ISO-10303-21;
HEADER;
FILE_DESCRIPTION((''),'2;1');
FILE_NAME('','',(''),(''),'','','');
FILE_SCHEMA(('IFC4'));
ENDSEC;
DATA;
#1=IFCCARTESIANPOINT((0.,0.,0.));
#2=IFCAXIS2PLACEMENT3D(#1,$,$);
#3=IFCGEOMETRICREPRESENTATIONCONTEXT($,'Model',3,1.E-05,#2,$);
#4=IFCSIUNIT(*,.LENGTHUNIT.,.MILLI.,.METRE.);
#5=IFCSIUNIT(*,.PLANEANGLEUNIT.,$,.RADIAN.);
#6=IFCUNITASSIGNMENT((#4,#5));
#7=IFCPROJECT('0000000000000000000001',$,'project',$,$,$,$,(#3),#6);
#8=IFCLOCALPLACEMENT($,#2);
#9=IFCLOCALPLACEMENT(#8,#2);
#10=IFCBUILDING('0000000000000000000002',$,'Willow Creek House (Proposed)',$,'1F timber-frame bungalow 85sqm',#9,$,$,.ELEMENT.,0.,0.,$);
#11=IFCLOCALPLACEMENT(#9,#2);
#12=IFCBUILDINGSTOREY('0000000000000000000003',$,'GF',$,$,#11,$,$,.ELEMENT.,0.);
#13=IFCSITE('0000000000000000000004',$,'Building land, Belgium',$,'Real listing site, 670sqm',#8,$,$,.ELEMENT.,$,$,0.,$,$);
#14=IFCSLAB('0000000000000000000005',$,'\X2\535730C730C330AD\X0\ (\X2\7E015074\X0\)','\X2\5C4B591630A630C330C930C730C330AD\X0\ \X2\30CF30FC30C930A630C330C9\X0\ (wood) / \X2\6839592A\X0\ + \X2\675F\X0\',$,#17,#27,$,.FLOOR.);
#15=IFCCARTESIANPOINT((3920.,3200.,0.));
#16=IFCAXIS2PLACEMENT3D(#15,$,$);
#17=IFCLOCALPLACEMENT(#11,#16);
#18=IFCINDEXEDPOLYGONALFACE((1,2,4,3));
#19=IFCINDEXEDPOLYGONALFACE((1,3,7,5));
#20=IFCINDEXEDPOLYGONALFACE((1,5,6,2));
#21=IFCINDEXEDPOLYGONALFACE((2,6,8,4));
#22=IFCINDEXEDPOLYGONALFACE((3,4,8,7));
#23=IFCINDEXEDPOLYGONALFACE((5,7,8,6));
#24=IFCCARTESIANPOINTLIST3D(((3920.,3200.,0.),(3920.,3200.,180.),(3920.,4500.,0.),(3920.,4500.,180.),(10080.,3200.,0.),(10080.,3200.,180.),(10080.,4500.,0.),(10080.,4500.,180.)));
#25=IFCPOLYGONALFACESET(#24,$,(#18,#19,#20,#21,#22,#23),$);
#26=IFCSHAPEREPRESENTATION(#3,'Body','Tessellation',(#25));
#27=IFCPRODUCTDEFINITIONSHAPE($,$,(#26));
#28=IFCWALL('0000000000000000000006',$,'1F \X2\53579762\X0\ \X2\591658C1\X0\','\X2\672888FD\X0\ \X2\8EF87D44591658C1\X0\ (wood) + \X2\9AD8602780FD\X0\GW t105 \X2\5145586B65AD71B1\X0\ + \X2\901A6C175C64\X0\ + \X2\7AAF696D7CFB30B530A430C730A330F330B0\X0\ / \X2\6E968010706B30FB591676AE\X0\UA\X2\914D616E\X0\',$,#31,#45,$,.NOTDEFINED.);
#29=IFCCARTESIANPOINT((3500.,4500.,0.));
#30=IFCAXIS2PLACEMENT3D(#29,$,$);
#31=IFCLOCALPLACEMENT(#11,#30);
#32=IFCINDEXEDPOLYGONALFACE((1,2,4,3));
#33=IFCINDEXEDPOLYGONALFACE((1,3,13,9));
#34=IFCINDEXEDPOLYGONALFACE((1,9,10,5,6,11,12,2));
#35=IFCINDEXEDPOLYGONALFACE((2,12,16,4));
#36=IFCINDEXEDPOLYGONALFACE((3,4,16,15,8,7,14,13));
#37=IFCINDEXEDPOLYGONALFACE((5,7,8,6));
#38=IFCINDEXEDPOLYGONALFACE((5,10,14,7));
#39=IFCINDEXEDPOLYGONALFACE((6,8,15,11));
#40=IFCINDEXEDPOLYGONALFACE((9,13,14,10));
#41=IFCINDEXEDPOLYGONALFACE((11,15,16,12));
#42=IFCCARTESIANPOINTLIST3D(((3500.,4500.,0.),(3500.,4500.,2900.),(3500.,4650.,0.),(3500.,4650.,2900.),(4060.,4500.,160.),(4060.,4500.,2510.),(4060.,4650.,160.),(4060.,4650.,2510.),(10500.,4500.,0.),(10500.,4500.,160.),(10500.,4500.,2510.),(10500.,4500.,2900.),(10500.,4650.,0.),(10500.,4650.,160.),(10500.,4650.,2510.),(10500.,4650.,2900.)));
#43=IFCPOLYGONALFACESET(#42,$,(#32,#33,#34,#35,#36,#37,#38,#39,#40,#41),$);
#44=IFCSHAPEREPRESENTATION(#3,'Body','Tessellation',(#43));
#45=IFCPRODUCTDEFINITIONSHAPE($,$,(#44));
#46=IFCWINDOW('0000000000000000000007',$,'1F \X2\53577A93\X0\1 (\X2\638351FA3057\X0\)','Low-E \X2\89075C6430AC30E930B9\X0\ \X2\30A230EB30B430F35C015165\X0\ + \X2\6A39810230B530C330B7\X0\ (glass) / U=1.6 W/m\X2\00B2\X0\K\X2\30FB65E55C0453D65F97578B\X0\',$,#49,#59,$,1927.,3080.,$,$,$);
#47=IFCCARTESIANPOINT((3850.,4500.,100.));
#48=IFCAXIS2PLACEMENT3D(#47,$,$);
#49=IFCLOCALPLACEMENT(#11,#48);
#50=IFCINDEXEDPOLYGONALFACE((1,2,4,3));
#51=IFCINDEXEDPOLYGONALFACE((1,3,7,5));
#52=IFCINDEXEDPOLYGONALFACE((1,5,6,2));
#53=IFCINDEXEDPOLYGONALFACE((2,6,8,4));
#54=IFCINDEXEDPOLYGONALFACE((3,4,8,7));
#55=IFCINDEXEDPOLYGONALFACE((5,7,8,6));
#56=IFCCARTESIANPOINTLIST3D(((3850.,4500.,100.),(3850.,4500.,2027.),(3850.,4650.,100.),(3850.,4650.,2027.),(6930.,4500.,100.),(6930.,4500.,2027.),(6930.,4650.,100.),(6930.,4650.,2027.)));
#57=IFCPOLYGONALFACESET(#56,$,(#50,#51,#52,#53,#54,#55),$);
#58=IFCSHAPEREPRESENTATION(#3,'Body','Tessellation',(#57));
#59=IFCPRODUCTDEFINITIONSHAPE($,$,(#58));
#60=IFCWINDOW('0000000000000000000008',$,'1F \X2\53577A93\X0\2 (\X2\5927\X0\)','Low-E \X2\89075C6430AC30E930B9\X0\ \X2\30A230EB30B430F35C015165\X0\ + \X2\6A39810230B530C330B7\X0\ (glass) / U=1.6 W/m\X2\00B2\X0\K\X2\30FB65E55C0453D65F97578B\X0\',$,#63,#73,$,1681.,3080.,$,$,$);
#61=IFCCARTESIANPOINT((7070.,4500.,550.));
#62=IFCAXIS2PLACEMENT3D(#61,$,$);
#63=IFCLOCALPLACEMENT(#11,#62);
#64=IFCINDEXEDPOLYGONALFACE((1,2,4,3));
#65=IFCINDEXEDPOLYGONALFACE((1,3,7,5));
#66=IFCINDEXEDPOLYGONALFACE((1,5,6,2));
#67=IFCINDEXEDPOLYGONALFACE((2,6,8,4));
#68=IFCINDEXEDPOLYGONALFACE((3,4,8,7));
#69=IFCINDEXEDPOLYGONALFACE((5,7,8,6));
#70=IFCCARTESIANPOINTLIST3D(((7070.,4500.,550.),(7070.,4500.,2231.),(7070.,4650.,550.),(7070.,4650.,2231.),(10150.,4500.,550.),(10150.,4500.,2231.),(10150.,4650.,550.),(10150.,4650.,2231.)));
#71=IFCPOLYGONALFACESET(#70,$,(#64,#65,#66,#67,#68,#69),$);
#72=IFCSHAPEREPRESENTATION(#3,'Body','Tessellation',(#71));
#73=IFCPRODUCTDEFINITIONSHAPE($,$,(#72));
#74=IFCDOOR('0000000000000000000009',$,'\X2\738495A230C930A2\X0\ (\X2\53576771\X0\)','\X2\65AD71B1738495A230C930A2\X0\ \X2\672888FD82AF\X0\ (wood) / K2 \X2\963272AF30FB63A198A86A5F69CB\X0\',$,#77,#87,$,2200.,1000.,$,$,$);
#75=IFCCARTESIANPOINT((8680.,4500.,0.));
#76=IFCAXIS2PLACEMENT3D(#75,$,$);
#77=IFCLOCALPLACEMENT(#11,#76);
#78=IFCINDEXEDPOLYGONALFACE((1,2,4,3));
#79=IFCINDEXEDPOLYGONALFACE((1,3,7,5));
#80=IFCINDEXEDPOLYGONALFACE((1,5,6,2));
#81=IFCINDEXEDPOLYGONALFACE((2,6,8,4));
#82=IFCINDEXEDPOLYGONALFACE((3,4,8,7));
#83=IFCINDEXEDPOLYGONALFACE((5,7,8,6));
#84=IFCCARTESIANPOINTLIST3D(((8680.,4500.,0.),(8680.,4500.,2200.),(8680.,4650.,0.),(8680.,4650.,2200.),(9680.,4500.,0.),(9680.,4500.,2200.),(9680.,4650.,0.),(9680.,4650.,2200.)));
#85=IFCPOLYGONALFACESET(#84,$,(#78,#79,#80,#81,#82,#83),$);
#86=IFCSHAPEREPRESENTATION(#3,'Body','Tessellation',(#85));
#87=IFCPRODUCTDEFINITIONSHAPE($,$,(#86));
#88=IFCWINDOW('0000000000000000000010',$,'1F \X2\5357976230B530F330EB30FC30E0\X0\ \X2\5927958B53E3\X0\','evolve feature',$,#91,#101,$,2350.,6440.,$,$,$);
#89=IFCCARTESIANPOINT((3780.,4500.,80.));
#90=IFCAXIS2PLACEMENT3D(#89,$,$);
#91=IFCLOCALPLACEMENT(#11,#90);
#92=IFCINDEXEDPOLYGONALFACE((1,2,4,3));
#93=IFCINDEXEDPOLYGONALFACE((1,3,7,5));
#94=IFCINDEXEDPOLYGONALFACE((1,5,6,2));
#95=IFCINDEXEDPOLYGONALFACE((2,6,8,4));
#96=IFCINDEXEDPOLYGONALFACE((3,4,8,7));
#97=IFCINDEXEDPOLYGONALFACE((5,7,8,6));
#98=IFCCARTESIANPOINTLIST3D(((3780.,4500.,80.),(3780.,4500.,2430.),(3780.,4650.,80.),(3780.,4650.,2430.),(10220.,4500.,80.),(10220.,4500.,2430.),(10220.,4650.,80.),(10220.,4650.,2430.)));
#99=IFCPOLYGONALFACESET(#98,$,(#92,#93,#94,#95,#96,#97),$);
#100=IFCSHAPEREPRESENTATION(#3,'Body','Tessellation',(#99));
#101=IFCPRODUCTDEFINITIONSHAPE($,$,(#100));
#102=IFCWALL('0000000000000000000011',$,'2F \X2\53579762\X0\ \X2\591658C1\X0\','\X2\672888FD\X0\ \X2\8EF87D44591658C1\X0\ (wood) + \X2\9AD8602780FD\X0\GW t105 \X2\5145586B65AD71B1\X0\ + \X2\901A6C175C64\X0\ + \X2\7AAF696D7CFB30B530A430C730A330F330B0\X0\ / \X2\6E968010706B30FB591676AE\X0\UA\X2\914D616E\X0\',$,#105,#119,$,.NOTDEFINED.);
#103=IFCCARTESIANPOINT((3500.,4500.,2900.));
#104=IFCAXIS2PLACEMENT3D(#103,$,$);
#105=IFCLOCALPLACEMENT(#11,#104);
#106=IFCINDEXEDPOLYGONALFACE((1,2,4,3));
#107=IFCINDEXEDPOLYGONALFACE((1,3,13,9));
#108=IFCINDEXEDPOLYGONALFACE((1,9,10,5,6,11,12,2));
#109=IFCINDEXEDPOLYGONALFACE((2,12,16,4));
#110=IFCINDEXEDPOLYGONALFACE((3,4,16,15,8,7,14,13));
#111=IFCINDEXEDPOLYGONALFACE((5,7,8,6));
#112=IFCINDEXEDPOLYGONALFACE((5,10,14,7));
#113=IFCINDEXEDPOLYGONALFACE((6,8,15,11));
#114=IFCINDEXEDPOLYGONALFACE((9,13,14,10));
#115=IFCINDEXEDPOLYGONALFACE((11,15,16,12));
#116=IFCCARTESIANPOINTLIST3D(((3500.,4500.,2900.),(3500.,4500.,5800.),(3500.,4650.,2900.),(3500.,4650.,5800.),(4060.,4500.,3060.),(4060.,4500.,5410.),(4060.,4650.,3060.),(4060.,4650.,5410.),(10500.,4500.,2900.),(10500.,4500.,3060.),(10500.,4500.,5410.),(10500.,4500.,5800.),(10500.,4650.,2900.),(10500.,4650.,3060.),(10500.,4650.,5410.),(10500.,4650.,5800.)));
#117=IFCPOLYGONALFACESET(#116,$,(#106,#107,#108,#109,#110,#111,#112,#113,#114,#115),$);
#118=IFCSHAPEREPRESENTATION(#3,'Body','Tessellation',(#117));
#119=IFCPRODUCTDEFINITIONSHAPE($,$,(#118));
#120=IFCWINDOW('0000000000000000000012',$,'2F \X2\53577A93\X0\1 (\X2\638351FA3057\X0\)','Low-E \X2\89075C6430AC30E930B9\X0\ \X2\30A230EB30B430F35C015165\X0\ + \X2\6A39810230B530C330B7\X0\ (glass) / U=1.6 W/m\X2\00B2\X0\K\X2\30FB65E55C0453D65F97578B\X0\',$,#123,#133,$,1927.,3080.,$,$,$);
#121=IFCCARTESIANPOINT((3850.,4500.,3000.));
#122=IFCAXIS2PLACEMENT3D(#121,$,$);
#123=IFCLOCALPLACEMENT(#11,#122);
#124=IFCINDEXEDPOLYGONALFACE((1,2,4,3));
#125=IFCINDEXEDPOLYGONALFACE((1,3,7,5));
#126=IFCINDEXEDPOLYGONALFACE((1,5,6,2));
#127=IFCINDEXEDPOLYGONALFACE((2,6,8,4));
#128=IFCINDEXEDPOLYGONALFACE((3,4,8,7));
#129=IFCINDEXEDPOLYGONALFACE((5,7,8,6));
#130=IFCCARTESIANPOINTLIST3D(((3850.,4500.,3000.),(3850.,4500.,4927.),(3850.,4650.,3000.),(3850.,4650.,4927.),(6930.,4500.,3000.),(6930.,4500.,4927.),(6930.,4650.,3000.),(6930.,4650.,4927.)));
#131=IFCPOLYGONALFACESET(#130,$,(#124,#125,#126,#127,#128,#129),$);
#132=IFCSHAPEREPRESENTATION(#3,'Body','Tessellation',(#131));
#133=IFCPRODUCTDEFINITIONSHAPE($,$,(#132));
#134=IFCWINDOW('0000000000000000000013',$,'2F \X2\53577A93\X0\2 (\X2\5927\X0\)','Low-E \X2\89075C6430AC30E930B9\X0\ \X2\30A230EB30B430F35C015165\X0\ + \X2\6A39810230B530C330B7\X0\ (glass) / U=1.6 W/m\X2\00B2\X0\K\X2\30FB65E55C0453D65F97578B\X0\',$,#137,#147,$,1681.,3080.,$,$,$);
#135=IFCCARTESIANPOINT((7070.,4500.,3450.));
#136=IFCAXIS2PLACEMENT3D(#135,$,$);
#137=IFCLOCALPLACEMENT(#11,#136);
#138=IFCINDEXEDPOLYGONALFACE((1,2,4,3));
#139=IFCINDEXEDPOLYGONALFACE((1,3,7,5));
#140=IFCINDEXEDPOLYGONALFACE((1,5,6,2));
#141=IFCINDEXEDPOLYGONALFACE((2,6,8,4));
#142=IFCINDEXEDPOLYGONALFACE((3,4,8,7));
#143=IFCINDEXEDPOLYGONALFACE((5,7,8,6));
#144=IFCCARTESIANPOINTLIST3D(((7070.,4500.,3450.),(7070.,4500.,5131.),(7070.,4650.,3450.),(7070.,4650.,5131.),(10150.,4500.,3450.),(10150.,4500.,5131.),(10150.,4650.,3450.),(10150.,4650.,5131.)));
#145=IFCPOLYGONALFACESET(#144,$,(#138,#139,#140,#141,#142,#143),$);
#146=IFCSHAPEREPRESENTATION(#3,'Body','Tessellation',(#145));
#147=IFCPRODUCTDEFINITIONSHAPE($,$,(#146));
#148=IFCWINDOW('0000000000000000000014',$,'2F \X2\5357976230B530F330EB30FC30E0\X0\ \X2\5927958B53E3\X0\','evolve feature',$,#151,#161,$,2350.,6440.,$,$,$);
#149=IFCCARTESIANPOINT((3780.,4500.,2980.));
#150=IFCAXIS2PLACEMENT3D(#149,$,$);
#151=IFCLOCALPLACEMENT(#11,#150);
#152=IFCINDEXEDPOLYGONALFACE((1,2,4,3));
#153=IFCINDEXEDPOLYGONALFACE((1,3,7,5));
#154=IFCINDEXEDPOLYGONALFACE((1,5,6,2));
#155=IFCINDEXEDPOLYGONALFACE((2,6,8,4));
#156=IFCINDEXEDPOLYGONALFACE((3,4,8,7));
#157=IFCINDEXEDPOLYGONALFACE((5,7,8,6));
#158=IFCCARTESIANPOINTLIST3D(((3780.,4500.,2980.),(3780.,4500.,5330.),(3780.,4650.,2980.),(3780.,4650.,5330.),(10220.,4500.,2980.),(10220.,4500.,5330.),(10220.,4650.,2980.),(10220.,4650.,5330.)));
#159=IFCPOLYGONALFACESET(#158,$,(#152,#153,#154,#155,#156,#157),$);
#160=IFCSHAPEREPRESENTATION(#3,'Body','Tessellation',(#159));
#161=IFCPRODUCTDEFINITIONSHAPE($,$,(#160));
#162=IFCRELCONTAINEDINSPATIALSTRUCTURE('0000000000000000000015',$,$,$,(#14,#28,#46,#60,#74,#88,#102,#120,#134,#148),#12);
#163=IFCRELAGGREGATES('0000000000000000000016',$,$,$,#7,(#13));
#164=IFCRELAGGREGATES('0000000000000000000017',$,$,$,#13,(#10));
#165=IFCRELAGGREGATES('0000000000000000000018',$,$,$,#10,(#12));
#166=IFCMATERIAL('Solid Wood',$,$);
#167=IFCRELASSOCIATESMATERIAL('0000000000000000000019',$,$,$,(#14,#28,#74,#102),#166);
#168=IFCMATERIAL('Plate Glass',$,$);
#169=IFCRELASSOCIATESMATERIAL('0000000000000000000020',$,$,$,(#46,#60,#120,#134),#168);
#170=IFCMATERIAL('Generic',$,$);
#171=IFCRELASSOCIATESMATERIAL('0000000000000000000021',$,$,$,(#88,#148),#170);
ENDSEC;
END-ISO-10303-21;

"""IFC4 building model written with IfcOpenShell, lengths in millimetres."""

from ifc_helpers import new_model, si_unit, frame, frame_2d, origin, place, context, project, spatial, rectangle, extrude, material, element, fill, save


model = new_model("IFC4")

# Units and contexts
model_context = context("Model", 3, precision=1e-05, world=origin())
ifc_project = project(units=[si_unit("LENGTHUNIT", "METRE", prefix="MILLI"), si_unit("PLANEANGLEUNIT", "RADIAN")], contexts=[model_context])

# Site, building, storey
site_placement = place(None, origin())
site = spatial("IfcSite", under=ifc_project, at=site_placement, Name="Building land, Belgium", ObjectType="Real listing site, 670sqm", CompositionType="ELEMENT", RefElevation=0.0)
building_placement = place(site_placement, origin())
building = spatial("IfcBuilding", under=site, at=building_placement, Name="Willow Creek House (Proposed)", ObjectType="1F timber-frame bungalow 85sqm", CompositionType="ELEMENT", ElevationOfRefHeight=0.0, ElevationOfTerrain=0.0)
storey_placement = place(building_placement, origin())
storey = spatial("IfcBuildingStorey", under=building, at=storey_placement, Name="GF", CompositionType="ELEMENT", Elevation=0.0)

# Slab
ifc_material_1 = material(Name="Solid Wood")
slab_1_placement = place(storey_placement, frame((3920.0, 3200.0, 0.0)))
element("IfcSlab", 1, at=slab_1_placement, inside=storey, material=ifc_material_1, Name="南デッキ (縁側)", Description="屋外ウッドデッキ ハードウッド (wood) / 根太 + 束", PredefinedType="FLOOR", context=model_context, shape_type="SweptSolid", body=[
    extrude(rectangle(XDim=6160.0, YDim=1300.0, at=frame_2d((3080.0, 650.0))), frame((3920.0, 3200.0, 0.0)), (0.0, 0.0, 1.0), 180.0),
])
ifc_material_2 = material(Name="Generic")

# Wall, openings, windows, door
wall_1_placement = place(storey_placement, frame((3500.0, 4500.0, 0.0)))
wall_1 = element("IfcWall", 2, at=wall_1_placement, inside=storey, material=ifc_material_1, Name="1F 南面 外壁", Description="木製 軸組外壁 (wood) + 高性能GW t105 充填断熱 + 通気層 + 窯業系サイディング / 準耐火・外皮UA配慮", PredefinedType="NOTDEFINED", context=model_context, shape_type="SweptSolid", body=[
    extrude(rectangle(XDim=7000.0, YDim=150.0, at=frame_2d((3500.0, 75.0))), frame((3500.0, 4500.0, 0.0)), (0.0, 0.0, 1.0), 2900.0),
])
opening_1_placement = place(storey_placement, frame((3850.0, 4500.0, 100.0)))
opening_1 = element("IfcOpeningElement", 3, at=opening_1_placement, cuts=wall_1, PredefinedType="NOTDEFINED", context=model_context, shape_type="SweptSolid", body=[
    extrude(rectangle(XDim=3080.0, YDim=150.0, at=frame_2d((1540.0, 75.0))), frame((3850.0, 4500.0, 100.0)), (0.0, 0.0, 1.0), 1927.0),
])
opening_2_placement = place(storey_placement, frame((7070.0, 4500.0, 550.0)))
opening_2 = element("IfcOpeningElement", 4, at=opening_2_placement, cuts=wall_1, PredefinedType="NOTDEFINED", context=model_context, shape_type="SweptSolid", body=[
    extrude(rectangle(XDim=3080.0, YDim=150.0, at=frame_2d((1540.0, 75.0))), frame((7070.0, 4500.0, 550.0)), (0.0, 0.0, 1.0), 1681.0),
])
opening_3_placement = place(storey_placement, frame((8680.0, 4500.0, 0.0)))
opening_3 = element("IfcOpeningElement", 5, at=opening_3_placement, cuts=wall_1, PredefinedType="NOTDEFINED", context=model_context, shape_type="SweptSolid", body=[
    extrude(rectangle(XDim=1000.0, YDim=150.0, at=frame_2d((500.0, 75.0))), frame((8680.0, 4500.0, 0.0)), (0.0, 0.0, 1.0), 2200.0),
])
opening_4_placement = place(storey_placement, frame((3780.0, 4500.0, 80.0)))
opening_4 = element("IfcOpeningElement", 6, at=opening_4_placement, cuts=wall_1, PredefinedType="NOTDEFINED", context=model_context, shape_type="SweptSolid", body=[
    extrude(rectangle(XDim=6440.0, YDim=150.0, at=frame_2d((3220.0, 75.0))), frame((3780.0, 4500.0, 80.0)), (0.0, 0.0, 1.0), 2350.0),
])
ifc_material_3 = material(Name="Plate Glass")
window_1_placement = place(storey_placement, frame((3850.0, 4500.0, 100.0)))
window_1 = element("IfcWindow", 7, at=window_1_placement, inside=storey, material=ifc_material_3, Name="1F 南窓1 (掃出し)", Description="Low-E 複層ガラス アルゴン封入 + 樹脂サッシ (glass) / U=1.6 W/m²K・日射取得型", OverallHeight=1927.0, OverallWidth=3080.0, context=model_context, shape_type="SweptSolid", body=[
    extrude(rectangle(XDim=3080.0, YDim=150.0, at=frame_2d((1540.0, 75.0))), frame((3850.0, 4500.0, 100.0)), (0.0, 0.0, 1.0), 1927.0),
])
fill(opening_1, window_1)
window_2_placement = place(storey_placement, frame((7070.0, 4500.0, 550.0)))
window_2 = element("IfcWindow", 8, at=window_2_placement, inside=storey, material=ifc_material_3, Name="1F 南窓2 (大)", Description="Low-E 複層ガラス アルゴン封入 + 樹脂サッシ (glass) / U=1.6 W/m²K・日射取得型", OverallHeight=1681.0, OverallWidth=3080.0, context=model_context, shape_type="SweptSolid", body=[
    extrude(rectangle(XDim=3080.0, YDim=150.0, at=frame_2d((1540.0, 75.0))), frame((7070.0, 4500.0, 550.0)), (0.0, 0.0, 1.0), 1681.0),
])
fill(opening_2, window_2)
door_placement = place(storey_placement, frame((8680.0, 4500.0, 0.0)))
door = element("IfcDoor", 9, at=door_placement, inside=storey, material=ifc_material_1, Name="玄関ドア (南東)", Description="断熱玄関ドア 木製芯 (wood) / K2 防犯・採風機構", OverallHeight=2200.0, OverallWidth=1000.0, context=model_context, shape_type="SweptSolid", body=[
    extrude(rectangle(XDim=1000.0, YDim=150.0, at=frame_2d((500.0, 75.0))), frame((8680.0, 4500.0, 0.0)), (0.0, 0.0, 1.0), 2200.0),
])
fill(opening_3, door)
window_3_placement = place(storey_placement, frame((3780.0, 4500.0, 80.0)))
window_3 = element("IfcWindow", 10, at=window_3_placement, inside=storey, material=ifc_material_2, Name="1F 南面サンルーム 大開口", Description="evolve feature", OverallHeight=2350.0, OverallWidth=6440.0, context=model_context, shape_type="SweptSolid", body=[
    extrude(rectangle(XDim=6440.0, YDim=150.0, at=frame_2d((3220.0, 75.0))), frame((3780.0, 4500.0, 80.0)), (0.0, 0.0, 1.0), 2350.0),
])
fill(opening_4, window_3)

# Wall, openings, windows
wall_2_placement = place(storey_placement, frame((3500.0, 4500.0, 2900.0)))
wall_2 = element("IfcWall", 11, at=wall_2_placement, inside=storey, material=ifc_material_1, Name="2F 南面 外壁", Description="木製 軸組外壁 (wood) + 高性能GW t105 充填断熱 + 通気層 + 窯業系サイディング / 準耐火・外皮UA配慮", PredefinedType="NOTDEFINED", context=model_context, shape_type="SweptSolid", body=[
    extrude(rectangle(XDim=7000.0, YDim=150.0, at=frame_2d((3500.0, 75.0))), frame((3500.0, 4500.0, 2900.0)), (0.0, 0.0, 1.0), 2900.0),
])
opening_5_placement = place(storey_placement, frame((3850.0, 4500.0, 3000.0)))
opening_5 = element("IfcOpeningElement", 12, at=opening_5_placement, cuts=wall_2, PredefinedType="NOTDEFINED", context=model_context, shape_type="SweptSolid", body=[
    extrude(rectangle(XDim=3080.0, YDim=150.0, at=frame_2d((1540.0, 75.0))), frame((3850.0, 4500.0, 3000.0)), (0.0, 0.0, 1.0), 1927.0),
])
opening_6_placement = place(storey_placement, frame((7070.0, 4500.0, 3450.0)))
opening_6 = element("IfcOpeningElement", 13, at=opening_6_placement, cuts=wall_2, PredefinedType="NOTDEFINED", context=model_context, shape_type="SweptSolid", body=[
    extrude(rectangle(XDim=3080.0, YDim=150.0, at=frame_2d((1540.0, 75.0))), frame((7070.0, 4500.0, 3450.0)), (0.0, 0.0, 1.0), 1681.0),
])
opening_7_placement = place(storey_placement, frame((3780.0, 4500.0, 2980.0)))
opening_7 = element("IfcOpeningElement", 14, at=opening_7_placement, cuts=wall_2, PredefinedType="NOTDEFINED", context=model_context, shape_type="SweptSolid", body=[
    extrude(rectangle(XDim=6440.0, YDim=150.0, at=frame_2d((3220.0, 75.0))), frame((3780.0, 4500.0, 2980.0)), (0.0, 0.0, 1.0), 2350.0),
])
window_4_placement = place(storey_placement, frame((3850.0, 4500.0, 3000.0)))
window_4 = element("IfcWindow", 15, at=window_4_placement, inside=storey, material=ifc_material_3, Name="2F 南窓1 (掃出し)", Description="Low-E 複層ガラス アルゴン封入 + 樹脂サッシ (glass) / U=1.6 W/m²K・日射取得型", OverallHeight=1927.0, OverallWidth=3080.0, context=model_context, shape_type="SweptSolid", body=[
    extrude(rectangle(XDim=3080.0, YDim=150.0, at=frame_2d((1540.0, 75.0))), frame((3850.0, 4500.0, 3000.0)), (0.0, 0.0, 1.0), 1927.0),
])
fill(opening_5, window_4)
window_5_placement = place(storey_placement, frame((7070.0, 4500.0, 3450.0)))
window_5 = element("IfcWindow", 16, at=window_5_placement, inside=storey, material=ifc_material_3, Name="2F 南窓2 (大)", Description="Low-E 複層ガラス アルゴン封入 + 樹脂サッシ (glass) / U=1.6 W/m²K・日射取得型", OverallHeight=1681.0, OverallWidth=3080.0, context=model_context, shape_type="SweptSolid", body=[
    extrude(rectangle(XDim=3080.0, YDim=150.0, at=frame_2d((1540.0, 75.0))), frame((7070.0, 4500.0, 3450.0)), (0.0, 0.0, 1.0), 1681.0),
])
fill(opening_6, window_5)
window_6_placement = place(storey_placement, frame((3780.0, 4500.0, 2980.0)))
window_6 = element("IfcWindow", 17, at=window_6_placement, inside=storey, material=ifc_material_2, Name="2F 南面サンルーム 大開口", Description="evolve feature", OverallHeight=2350.0, OverallWidth=6440.0, context=model_context, shape_type="SweptSolid", body=[
    extrude(rectangle(XDim=6440.0, YDim=150.0, at=frame_2d((3220.0, 75.0))), frame((3780.0, 4500.0, 2980.0)), (0.0, 0.0, 1.0), 2350.0),
])
fill(opening_7, window_6)

save(model, "model.ifc")
